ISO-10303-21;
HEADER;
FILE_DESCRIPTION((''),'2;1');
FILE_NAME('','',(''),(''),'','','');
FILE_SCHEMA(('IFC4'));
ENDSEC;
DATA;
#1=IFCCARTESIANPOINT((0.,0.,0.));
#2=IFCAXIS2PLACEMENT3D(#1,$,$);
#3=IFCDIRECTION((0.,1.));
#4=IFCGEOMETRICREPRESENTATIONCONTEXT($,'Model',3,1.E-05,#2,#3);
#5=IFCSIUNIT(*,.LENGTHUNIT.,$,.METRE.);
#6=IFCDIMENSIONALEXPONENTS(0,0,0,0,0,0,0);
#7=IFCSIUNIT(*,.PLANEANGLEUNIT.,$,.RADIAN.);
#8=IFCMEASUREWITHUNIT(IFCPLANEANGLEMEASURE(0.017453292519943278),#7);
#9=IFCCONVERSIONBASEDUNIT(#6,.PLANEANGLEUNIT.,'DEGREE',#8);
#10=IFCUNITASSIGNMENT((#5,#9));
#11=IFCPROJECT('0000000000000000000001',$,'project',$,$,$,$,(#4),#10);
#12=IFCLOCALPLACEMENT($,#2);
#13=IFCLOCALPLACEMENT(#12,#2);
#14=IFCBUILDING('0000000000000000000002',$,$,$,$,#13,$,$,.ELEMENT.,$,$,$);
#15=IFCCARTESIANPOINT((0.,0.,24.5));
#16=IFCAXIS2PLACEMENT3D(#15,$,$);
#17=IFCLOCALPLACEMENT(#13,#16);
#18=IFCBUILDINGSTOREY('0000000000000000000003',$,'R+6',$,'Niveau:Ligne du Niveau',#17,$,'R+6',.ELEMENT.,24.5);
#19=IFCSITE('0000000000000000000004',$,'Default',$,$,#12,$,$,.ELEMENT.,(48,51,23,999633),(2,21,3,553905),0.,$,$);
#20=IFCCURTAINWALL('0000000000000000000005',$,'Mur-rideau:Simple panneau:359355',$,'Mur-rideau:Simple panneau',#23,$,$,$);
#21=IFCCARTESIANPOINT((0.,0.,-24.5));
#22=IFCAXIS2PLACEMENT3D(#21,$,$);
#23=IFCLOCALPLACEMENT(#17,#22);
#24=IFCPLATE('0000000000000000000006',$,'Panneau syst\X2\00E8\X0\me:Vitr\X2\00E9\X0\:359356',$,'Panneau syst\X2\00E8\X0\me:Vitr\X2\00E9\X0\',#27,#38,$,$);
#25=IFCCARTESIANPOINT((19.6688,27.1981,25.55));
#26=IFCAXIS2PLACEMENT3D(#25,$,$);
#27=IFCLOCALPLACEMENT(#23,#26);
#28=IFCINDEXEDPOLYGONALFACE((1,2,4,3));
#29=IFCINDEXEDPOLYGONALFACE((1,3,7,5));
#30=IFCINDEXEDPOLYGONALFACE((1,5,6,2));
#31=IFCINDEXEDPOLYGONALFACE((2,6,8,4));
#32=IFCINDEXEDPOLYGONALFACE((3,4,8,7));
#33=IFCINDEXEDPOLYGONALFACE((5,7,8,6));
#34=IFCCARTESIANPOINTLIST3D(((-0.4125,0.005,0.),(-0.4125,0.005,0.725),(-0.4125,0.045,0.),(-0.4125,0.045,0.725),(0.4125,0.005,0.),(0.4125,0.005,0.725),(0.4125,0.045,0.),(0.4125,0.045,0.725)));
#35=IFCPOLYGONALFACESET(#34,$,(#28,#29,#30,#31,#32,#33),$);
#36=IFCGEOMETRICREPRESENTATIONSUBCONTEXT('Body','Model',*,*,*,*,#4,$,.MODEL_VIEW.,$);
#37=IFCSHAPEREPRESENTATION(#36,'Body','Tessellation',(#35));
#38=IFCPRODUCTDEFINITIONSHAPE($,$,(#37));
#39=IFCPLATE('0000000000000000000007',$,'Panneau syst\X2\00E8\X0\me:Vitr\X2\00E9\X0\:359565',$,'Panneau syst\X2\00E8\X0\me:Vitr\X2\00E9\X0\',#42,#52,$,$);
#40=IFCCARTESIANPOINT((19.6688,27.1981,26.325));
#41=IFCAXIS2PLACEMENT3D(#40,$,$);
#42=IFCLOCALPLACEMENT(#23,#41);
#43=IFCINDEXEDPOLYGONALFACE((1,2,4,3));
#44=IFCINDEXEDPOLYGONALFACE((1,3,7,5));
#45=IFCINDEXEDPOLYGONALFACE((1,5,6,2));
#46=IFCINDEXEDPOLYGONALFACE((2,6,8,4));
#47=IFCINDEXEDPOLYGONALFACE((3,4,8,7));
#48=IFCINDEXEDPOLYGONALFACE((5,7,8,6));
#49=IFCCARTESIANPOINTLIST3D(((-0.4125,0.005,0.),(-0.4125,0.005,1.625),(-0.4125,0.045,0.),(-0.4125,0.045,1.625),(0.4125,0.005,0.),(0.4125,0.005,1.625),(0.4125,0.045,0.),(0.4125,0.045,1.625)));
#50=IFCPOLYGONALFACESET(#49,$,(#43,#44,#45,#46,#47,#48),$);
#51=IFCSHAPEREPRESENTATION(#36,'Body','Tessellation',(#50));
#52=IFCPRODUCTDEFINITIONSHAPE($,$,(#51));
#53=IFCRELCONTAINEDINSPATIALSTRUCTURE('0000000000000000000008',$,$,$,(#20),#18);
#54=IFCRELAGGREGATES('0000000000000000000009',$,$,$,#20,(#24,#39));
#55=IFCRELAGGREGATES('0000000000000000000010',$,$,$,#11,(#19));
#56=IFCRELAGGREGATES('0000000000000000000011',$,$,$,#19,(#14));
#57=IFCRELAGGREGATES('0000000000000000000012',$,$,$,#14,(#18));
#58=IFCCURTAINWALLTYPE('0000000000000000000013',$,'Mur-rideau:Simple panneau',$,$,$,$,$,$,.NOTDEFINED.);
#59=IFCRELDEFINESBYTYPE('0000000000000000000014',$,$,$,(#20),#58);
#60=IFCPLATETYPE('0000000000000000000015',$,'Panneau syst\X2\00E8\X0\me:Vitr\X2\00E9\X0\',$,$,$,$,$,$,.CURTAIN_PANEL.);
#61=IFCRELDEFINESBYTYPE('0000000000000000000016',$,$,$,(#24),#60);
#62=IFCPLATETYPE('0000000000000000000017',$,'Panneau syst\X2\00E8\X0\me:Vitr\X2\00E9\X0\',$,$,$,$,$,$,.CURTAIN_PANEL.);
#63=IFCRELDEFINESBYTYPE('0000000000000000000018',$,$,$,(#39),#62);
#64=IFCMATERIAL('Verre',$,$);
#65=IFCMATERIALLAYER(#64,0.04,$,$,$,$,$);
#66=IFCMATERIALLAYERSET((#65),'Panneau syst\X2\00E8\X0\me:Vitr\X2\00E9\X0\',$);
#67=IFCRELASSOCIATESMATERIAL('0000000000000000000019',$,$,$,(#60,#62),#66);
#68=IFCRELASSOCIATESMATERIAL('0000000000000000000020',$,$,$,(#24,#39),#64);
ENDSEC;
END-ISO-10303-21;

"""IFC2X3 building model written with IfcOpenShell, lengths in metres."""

from ifc_helpers import new_model, entity, si_unit, converted_unit, direction, frame, frame_2d, origin, place, context, subcontext, project, spatial, rectangle, extrude, source, transform, mapped, material, layer, layer_set, type_object, type_shapes, element, aggregate, save


model = new_model("IFC2X3")

# Units and contexts
model_context = context("Model", 3, precision=1e-05, world=origin(), true_north=direction((0.0, 1.0)))
body_context = subcontext(model_context, "Body", "Model", "MODEL_VIEW")
ifc_project = project(units=[si_unit("LENGTHUNIT", "METRE"), converted_unit("PLANEANGLEUNIT", "DEGREE", entity("IfcPlaneAngleMeasure", 0.017453292519943278), si_unit("PLANEANGLEUNIT", "RADIAN"), dimensions=[0, 0, 0, 0, 0, 0, 0])], contexts=[model_context])

# Site, building, storey
site_placement = place(None, origin())
site = spatial("IfcSite", under=ifc_project, at=site_placement, Name="Default", CompositionType="ELEMENT", RefLatitude=(48, 51, 23, 999633), RefLongitude=(2, 21, 3, 553905), RefElevation=0.0)
building_placement = place(site_placement, origin())
building = spatial("IfcBuilding", under=site, at=building_placement, CompositionType="ELEMENT")
storey_placement = place(building_placement, frame((0.0, 0.0, 24.5)))
storey = spatial("IfcBuildingStorey", under=building, at=storey_placement, Name="R+6", ObjectType="Niveau:Ligne du Niveau", LongName="R+6", CompositionType="ELEMENT", Elevation=24.5)

# Curtain wall
curtain_wall_type = type_object("IfcCurtainWallType", Name="Mur-rideau:Simple panneau", PredefinedType="NOTDEFINED")
curtain_wall_1_placement = place(storey_placement, frame((0.0, 0.0, -24.5)))
curtain_wall_1 = element("IfcCurtainWall", 1, at=curtain_wall_1_placement, inside=storey, type_object=curtain_wall_type, Name="Mur-rideau:Simple panneau:359355", ObjectType="Mur-rideau:Simple panneau")

# Plates
ifc_material_1 = material(Name="Verre")
ifc_layer_1 = layer(ifc_material_1, 0.04)
ifc_layer_set_1 = layer_set([ifc_layer_1], Name="Panneau système:Vitré")
plate_type_1 = type_object("IfcPlateType", Name="Panneau système:Vitré", PredefinedType="CURTAIN_PANEL", material=ifc_layer_set_1)
shared_shape_1 = source(origin(), body_context, "Body", "SweptSolid", [
    extrude(rectangle(XDim=0.04, YDim=0.825, at=frame_2d((0.0, 0.0), x_axis=(1.0, 0.0))), frame((0.0, 0.025, 0.0), z_axis=(0.0, 0.0, 1.0), x_axis=(0.0, 1.0, 0.0)), (0.0, 0.0, 1.0), 0.725),
])
type_shapes(plate_type_1, [shared_shape_1])
plate_1_placement = place(curtain_wall_1_placement, frame((19.6688, 27.1981, 25.55)))
plate_1 = element("IfcPlate", 2, at=plate_1_placement, type_object=plate_type_1, material=ifc_material_1, Name="Panneau système:Vitré:359356", ObjectType="Panneau système:Vitré", context=body_context, shape_type="MappedRepresentation", body=[
    mapped(shared_shape_1, transform((0.0, 0.0, 0.0), scale=1.0)),
])
plate_type_2 = type_object("IfcPlateType", Name="Panneau système:Vitré", PredefinedType="CURTAIN_PANEL", material=ifc_layer_set_1)
shared_shape_2 = source(origin(), body_context, "Body", "SweptSolid", [
    extrude(rectangle(XDim=0.04, YDim=0.825, at=frame_2d((0.0, 0.0), x_axis=(1.0, 0.0))), frame((0.0, 0.025, 0.0), z_axis=(0.0, 0.0, 1.0), x_axis=(0.0, 1.0, 0.0)), (0.0, 0.0, 1.0), 1.625),
])
type_shapes(plate_type_2, [shared_shape_2])
plate_2_placement = place(curtain_wall_1_placement, frame((19.6688, 27.1981, 26.325)))
plate_2 = element("IfcPlate", 3, at=plate_2_placement, type_object=plate_type_2, material=ifc_material_1, Name="Panneau système:Vitré:359565", ObjectType="Panneau système:Vitré", context=body_context, shape_type="MappedRepresentation", body=[
    mapped(shared_shape_2, transform((0.0, 0.0, 0.0), scale=1.0)),
])
aggregate(curtain_wall_1, [plate_1, plate_2])

save(model, "model.ifc")
